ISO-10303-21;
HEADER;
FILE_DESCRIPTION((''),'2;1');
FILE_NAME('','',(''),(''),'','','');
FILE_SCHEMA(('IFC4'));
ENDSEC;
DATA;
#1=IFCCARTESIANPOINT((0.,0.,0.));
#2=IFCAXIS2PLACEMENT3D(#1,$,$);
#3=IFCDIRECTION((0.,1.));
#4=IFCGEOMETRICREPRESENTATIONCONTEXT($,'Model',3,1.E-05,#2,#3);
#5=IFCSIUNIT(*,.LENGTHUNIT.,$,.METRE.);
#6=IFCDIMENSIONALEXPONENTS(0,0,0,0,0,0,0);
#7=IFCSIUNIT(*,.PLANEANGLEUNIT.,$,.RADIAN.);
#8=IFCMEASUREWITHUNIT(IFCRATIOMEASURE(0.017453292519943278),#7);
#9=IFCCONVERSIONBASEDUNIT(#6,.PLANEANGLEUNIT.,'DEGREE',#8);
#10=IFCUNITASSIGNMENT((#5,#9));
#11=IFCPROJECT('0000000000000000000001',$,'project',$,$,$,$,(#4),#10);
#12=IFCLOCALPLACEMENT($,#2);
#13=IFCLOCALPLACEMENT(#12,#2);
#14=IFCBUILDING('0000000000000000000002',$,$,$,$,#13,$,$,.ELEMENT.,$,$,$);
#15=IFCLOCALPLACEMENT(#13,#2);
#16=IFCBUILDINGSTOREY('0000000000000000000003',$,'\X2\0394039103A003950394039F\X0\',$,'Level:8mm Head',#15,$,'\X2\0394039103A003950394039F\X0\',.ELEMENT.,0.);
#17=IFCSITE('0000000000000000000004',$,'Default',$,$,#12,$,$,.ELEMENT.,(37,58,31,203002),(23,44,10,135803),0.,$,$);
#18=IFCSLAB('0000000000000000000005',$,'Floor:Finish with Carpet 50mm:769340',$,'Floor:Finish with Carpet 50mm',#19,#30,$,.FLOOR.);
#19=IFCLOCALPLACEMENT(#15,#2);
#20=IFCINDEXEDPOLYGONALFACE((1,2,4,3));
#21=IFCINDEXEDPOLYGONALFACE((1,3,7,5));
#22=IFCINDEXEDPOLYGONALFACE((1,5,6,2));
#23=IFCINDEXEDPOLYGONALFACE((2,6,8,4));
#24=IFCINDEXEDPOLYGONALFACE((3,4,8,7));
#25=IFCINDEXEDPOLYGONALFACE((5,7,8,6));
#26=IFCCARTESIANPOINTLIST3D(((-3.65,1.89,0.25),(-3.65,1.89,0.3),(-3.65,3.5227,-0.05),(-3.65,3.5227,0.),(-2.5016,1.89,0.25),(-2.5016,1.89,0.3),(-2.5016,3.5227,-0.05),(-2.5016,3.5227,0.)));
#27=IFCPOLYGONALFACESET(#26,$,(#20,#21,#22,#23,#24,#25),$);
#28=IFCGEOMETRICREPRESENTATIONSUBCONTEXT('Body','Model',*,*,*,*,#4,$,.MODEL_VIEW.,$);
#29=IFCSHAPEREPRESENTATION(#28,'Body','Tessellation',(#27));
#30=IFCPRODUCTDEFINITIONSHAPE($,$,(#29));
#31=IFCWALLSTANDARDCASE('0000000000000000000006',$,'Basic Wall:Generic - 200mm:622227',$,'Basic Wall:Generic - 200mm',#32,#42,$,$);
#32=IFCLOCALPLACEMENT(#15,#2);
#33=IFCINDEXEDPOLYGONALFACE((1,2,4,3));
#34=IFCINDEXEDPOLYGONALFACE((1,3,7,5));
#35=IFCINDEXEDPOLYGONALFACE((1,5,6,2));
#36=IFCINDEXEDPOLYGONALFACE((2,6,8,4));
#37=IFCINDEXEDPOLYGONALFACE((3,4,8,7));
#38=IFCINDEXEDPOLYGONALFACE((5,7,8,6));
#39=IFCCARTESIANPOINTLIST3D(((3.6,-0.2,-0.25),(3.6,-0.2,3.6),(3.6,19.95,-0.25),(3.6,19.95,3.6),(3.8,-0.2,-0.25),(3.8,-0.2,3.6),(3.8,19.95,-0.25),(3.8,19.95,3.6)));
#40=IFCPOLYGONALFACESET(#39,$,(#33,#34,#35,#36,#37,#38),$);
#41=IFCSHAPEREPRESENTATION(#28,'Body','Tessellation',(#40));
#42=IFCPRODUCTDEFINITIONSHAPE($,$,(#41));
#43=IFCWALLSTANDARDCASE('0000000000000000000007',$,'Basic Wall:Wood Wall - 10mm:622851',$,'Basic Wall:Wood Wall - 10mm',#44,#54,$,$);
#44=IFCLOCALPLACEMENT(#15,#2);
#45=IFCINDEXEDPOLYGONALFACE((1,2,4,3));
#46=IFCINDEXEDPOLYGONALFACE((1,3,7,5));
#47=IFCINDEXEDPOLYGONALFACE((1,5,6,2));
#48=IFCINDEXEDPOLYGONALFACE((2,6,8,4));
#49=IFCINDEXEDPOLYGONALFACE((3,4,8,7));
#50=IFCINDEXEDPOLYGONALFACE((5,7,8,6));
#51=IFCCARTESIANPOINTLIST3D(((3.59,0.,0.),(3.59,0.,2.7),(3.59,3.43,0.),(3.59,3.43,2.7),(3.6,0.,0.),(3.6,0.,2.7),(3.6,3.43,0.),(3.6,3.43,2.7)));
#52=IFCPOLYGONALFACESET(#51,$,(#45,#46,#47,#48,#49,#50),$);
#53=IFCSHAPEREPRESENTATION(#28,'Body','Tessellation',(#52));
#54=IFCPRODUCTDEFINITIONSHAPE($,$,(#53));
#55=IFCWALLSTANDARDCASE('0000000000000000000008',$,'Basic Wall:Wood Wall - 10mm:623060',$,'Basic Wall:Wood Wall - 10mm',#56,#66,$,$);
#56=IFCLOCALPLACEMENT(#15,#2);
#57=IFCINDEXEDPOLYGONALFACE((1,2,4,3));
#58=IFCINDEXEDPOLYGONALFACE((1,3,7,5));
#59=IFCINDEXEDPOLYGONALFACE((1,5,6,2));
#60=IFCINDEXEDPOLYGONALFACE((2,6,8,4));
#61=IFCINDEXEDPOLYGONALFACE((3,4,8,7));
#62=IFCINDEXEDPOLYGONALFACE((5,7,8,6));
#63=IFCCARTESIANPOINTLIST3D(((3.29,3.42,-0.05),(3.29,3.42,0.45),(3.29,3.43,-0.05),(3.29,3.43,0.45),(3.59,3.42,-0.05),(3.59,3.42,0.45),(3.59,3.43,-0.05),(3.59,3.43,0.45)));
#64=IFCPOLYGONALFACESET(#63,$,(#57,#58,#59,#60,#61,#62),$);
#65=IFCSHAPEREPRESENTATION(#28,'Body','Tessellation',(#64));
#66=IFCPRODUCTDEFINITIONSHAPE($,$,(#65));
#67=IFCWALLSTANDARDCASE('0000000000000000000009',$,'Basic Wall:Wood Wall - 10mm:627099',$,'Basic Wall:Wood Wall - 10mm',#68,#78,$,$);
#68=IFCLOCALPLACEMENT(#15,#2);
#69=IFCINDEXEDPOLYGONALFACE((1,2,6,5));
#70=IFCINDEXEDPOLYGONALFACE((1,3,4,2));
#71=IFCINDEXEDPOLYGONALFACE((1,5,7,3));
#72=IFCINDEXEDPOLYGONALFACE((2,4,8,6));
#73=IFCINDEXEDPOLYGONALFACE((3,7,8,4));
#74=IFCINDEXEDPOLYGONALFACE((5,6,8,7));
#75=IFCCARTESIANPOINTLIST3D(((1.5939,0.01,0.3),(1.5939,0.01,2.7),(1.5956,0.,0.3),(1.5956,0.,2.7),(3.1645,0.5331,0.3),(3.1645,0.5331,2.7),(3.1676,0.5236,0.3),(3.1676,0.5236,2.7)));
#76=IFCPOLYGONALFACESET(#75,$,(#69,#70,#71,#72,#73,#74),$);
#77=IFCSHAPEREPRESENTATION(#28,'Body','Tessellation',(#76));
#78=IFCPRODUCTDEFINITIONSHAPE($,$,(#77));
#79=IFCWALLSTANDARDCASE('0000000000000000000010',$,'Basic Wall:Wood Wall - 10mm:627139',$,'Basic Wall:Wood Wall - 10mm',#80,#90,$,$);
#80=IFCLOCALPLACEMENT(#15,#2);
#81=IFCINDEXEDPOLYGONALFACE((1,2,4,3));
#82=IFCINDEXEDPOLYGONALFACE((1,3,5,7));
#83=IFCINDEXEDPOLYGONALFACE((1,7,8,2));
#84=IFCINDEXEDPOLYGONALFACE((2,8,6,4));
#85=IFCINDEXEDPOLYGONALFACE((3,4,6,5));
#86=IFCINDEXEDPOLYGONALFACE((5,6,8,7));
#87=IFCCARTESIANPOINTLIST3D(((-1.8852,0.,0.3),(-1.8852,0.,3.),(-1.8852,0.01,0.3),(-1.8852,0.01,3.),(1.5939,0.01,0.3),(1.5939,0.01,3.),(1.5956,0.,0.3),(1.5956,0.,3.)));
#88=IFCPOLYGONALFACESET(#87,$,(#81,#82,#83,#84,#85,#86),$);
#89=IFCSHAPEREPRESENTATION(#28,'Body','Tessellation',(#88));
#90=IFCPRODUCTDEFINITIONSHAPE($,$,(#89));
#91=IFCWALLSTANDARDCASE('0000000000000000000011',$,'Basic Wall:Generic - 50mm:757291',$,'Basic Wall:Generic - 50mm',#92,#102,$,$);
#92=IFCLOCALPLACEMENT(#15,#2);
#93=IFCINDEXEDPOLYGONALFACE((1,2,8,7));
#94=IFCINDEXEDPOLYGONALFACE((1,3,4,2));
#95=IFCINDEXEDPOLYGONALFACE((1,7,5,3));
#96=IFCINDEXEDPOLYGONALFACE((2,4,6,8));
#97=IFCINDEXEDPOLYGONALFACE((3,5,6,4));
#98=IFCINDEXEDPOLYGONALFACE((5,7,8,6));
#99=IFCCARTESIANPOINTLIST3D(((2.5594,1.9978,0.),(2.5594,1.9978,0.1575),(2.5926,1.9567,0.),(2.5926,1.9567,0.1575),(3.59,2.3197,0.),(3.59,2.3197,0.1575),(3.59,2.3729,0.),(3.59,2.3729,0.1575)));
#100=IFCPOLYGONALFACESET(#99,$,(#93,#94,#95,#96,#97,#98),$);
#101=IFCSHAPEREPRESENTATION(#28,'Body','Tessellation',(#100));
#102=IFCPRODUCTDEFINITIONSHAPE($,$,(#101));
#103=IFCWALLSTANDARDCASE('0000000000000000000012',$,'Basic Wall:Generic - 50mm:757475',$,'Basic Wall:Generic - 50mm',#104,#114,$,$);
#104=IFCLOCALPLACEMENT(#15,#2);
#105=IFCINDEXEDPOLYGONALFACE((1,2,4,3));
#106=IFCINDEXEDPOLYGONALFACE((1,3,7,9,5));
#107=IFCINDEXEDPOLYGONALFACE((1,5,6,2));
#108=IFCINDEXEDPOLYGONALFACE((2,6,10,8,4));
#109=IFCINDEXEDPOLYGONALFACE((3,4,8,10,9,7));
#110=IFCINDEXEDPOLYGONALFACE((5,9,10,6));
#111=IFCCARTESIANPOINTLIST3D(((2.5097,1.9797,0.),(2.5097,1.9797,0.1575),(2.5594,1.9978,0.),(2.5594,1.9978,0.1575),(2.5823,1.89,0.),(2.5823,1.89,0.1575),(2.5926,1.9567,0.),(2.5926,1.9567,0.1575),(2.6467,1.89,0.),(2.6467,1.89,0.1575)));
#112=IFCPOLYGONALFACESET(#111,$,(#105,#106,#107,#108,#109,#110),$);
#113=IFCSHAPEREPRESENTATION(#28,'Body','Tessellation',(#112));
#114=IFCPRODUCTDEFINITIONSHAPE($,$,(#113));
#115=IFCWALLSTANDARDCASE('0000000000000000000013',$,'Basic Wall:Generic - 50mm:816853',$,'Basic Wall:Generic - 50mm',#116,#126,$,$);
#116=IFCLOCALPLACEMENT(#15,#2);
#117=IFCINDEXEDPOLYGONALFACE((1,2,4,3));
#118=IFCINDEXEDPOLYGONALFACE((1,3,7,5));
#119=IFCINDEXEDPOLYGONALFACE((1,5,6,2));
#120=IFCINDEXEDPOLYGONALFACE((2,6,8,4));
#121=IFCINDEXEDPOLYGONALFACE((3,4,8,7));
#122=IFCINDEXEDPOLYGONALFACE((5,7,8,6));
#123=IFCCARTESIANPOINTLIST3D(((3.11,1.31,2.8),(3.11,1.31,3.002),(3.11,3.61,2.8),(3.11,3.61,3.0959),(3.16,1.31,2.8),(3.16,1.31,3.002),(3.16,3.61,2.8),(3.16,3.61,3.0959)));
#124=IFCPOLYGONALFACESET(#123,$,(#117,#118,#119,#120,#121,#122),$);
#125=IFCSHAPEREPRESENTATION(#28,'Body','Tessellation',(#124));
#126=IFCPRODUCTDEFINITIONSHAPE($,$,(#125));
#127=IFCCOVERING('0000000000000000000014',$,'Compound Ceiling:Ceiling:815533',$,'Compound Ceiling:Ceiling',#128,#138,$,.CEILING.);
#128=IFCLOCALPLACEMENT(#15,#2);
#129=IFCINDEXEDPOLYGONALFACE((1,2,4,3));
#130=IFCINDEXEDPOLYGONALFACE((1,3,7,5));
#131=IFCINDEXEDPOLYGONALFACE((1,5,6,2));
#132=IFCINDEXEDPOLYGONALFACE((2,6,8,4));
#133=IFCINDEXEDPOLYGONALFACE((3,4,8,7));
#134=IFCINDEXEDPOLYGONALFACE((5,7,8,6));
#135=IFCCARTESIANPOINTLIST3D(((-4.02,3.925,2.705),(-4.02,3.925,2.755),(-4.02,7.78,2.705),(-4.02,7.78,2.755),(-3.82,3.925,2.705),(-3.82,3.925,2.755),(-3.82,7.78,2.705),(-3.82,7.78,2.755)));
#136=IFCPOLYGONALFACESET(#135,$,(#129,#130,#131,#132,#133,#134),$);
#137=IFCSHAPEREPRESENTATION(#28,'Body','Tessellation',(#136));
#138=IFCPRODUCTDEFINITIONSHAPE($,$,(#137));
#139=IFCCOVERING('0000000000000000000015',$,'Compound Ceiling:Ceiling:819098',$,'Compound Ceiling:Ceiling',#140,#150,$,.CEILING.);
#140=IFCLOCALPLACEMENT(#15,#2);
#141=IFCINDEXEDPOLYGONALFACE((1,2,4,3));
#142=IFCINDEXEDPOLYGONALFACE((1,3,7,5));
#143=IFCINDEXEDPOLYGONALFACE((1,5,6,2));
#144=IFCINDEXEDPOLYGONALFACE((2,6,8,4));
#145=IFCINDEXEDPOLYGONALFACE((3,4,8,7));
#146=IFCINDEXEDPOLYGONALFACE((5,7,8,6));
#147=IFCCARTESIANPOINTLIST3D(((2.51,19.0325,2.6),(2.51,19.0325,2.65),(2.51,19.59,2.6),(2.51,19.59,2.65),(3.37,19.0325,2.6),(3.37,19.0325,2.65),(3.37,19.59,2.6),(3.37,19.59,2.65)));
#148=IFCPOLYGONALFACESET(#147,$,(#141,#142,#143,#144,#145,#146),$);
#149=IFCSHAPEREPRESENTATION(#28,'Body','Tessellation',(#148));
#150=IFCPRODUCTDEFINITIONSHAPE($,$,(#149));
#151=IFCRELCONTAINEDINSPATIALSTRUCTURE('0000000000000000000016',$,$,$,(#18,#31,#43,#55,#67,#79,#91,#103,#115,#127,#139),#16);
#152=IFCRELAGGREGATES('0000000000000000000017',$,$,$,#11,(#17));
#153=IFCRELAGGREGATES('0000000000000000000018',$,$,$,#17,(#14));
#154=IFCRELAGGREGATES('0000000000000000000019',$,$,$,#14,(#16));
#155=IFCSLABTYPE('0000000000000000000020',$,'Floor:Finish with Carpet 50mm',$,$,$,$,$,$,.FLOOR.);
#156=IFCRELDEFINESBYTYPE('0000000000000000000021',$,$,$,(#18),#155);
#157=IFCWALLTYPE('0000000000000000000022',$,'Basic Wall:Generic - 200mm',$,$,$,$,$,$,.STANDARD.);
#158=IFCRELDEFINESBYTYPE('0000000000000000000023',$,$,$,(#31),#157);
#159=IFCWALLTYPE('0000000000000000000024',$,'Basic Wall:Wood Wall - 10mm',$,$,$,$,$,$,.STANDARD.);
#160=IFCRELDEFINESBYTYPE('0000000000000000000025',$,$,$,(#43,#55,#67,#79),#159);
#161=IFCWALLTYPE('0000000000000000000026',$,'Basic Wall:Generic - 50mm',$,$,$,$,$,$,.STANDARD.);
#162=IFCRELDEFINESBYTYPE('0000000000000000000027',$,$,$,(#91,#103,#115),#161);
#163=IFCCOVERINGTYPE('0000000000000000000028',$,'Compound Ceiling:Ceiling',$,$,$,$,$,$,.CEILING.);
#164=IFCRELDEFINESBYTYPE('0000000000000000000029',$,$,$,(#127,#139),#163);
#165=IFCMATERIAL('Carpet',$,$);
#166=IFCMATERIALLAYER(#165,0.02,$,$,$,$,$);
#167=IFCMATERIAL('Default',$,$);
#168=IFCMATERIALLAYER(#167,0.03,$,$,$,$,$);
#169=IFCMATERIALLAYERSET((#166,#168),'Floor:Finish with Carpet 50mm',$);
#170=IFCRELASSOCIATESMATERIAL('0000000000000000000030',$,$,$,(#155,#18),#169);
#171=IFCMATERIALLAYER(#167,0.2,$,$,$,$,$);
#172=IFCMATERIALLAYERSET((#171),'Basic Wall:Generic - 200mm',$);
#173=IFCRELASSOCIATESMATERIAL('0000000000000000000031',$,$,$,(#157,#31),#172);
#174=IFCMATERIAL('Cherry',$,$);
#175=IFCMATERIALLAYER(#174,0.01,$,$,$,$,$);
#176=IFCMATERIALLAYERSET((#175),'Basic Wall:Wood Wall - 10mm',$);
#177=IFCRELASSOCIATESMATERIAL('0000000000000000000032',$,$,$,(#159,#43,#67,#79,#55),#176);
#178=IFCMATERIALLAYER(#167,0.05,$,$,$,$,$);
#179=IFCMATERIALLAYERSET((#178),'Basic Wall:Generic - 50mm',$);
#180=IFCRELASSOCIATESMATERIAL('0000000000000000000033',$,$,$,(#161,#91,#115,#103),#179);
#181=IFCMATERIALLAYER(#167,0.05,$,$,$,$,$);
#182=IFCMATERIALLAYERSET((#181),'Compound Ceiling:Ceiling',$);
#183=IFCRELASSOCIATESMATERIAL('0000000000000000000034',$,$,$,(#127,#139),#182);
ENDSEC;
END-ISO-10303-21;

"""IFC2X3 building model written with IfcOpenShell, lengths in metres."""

from ifc_helpers import new_model, entity, si_unit, converted_unit, direction, frame, frame_2d, origin, place, context, subcontext, project, spatial, polyline, rectangle, outline, extrude, clip, halfspace, bounded_halfspace, material, layer, layer_set, layer_usage, type_object, element, save


model = new_model("IFC2X3")

# Units and contexts
model_context = context("Model", 3, precision=1e-05, world=origin(), true_north=direction((0.0, 1.0)))
body_context = subcontext(model_context, "Body", "Model", "MODEL_VIEW")
ifc_project = project(units=[si_unit("LENGTHUNIT", "METRE"), converted_unit("PLANEANGLEUNIT", "DEGREE", entity("IfcRatioMeasure", 0.017453292519943278), si_unit("PLANEANGLEUNIT", "RADIAN"), dimensions=[0, 0, 0, 0, 0, 0, 0])], contexts=[model_context])

# Site, building, storey
site_placement = place(None, origin())
site = spatial("IfcSite", under=ifc_project, at=site_placement, Name="Default", CompositionType="ELEMENT", RefLatitude=(37, 58, 31, 203002), RefLongitude=(23, 44, 10, 135803), RefElevation=0.0)
building_placement = place(site_placement, origin())
building = spatial("IfcBuilding", under=site, at=building_placement, CompositionType="ELEMENT")
storey_placement = place(building_placement, origin())
storey = spatial("IfcBuildingStorey", under=building, at=storey_placement, Name="ΔΑΠΕΔΟ", ObjectType="Level:8mm Head", LongName="ΔΑΠΕΔΟ", CompositionType="ELEMENT", Elevation=0.0)

# Slab
ifc_material_1 = material(Name="Carpet")
ifc_layer_1 = layer(ifc_material_1, 0.02)
ifc_material_2 = material(Name="Default")
ifc_layer_2 = layer(ifc_material_2, 0.03)
ifc_layer_set_1 = layer_set([ifc_layer_1, ifc_layer_2], Name="Floor:Finish with Carpet 50mm")
ifc_layer_usage_1 = layer_usage(ifc_layer_set_1, "AXIS3", "POSITIVE", 0.0)
slab_type = type_object("IfcSlabType", Name="Floor:Finish with Carpet 50mm", PredefinedType="FLOOR", material=ifc_layer_set_1)
slab_1_placement = place(storey_placement, origin())
element("IfcSlab", 1, at=slab_1_placement, inside=storey, type_object=slab_type, material=ifc_layer_usage_1, Name="Floor:Finish with Carpet 50mm:769340", ObjectType="Floor:Finish with Carpet 50mm", PredefinedType="FLOOR", context=body_context, shape_type="SweptSolid", body=[
    clip(clip(extrude(rectangle(XDim=1.66, YDim=1.1484, at=frame_2d((0.0, 0.0), x_axis=(1.0, 0.0))), frame((-3.0758, 2.7063, 0.15), z_axis=(0.0, -0.180721, -0.983534), x_axis=(0.0, 0.983534, -0.180721)), (0.180721, 0.0, 0.983534), 0.0508), halfspace(frame((-3.0758, 2.7063, 0.1), z_axis=(0.0, -0.180721, -0.983534), x_axis=(0.0, -0.983534, 0.180721)), False)), halfspace(frame((-3.0758, 2.7063, 0.15), z_axis=(0.0, 0.180721, 0.983534), x_axis=(0.0, -0.983534, 0.180721)), False)),
])

# Walls
ifc_layer_3 = layer(ifc_material_2, 0.2)
ifc_layer_set_2 = layer_set([ifc_layer_3], Name="Basic Wall:Generic - 200mm")
ifc_layer_usage_2 = layer_usage(ifc_layer_set_2, "AXIS2", "NEGATIVE", 0.1)
wall_type_1 = type_object("IfcWallType", Name="Basic Wall:Generic - 200mm", PredefinedType="STANDARD", material=ifc_layer_set_2)
wall_1_placement = place(storey_placement, frame((3.7, -0.2, -0.25), z_axis=(0.0, 0.0, 1.0), x_axis=(0.0, 1.0, 0.0)))
element("IfcWallStandardCase", 2, at=wall_1_placement, inside=storey, type_object=wall_type_1, material=ifc_layer_usage_2, Name="Basic Wall:Generic - 200mm:622227", ObjectType="Basic Wall:Generic - 200mm", context=body_context, shape_type="SweptSolid", body=[
    extrude(rectangle(XDim=20.15, YDim=0.2, at=frame_2d((10.075, 0.0), x_axis=(-1.0, 0.0))), origin(), (0.0, 0.0, 1.0), 3.85),
])
ifc_material_3 = material(Name="Cherry")
ifc_layer_4 = layer(ifc_material_3, 0.01)
ifc_layer_set_3 = layer_set([ifc_layer_4], Name="Basic Wall:Wood Wall - 10mm")
ifc_layer_usage_3 = layer_usage(ifc_layer_set_3, "AXIS2", "NEGATIVE", 0.005)
wall_type_2 = type_object("IfcWallType", Name="Basic Wall:Wood Wall - 10mm", PredefinedType="STANDARD", material=ifc_layer_set_3)
wall_2_placement = place(storey_placement, frame((3.595, 0.0, 0.0), z_axis=(0.0, 0.0, 1.0), x_axis=(0.0, 1.0, 0.0)))
element("IfcWallStandardCase", 3, at=wall_2_placement, inside=storey, type_object=wall_type_2, material=ifc_layer_usage_3, Name="Basic Wall:Wood Wall - 10mm:622851", ObjectType="Basic Wall:Wood Wall - 10mm", context=body_context, shape_type="Clipping", body=[
    clip(extrude(rectangle(XDim=3.43, YDim=0.01, at=frame_2d((1.715, 0.0), x_axis=(-1.0, 0.0))), origin(), (0.0, 0.0, 1.0), 2.7), bounded_halfspace(frame((0.0, -0.005, 2.7), z_axis=(0.0, 0.0, -1.0), x_axis=(0.0, -1.0, 0.0)), True, frame((0.0, -0.005, 2.7)), polyline([(0.0, 0.0), (1.31, 0.0), (1.31, 0.01), (0.0, 0.01), (0.0, 0.0)]))),
])
ifc_layer_usage_4 = layer_usage(ifc_layer_set_3, "AXIS2", "POSITIVE", -0.005)
wall_3_placement = place(storey_placement, frame((3.59, 3.425, -0.05), z_axis=(0.0, 0.0, 1.0), x_axis=(-1.0, 0.0, 0.0)))
element("IfcWallStandardCase", 4, at=wall_3_placement, inside=storey, type_object=wall_type_2, material=ifc_layer_usage_4, Name="Basic Wall:Wood Wall - 10mm:623060", ObjectType="Basic Wall:Wood Wall - 10mm", context=body_context, shape_type="Clipping", body=[
    clip(extrude(rectangle(XDim=0.3, YDim=0.01, at=frame_2d((0.15, 0.0), x_axis=(-1.0, 0.0))), origin(), (0.0, 0.0, 1.0), 0.5), bounded_halfspace(frame((0.3, -0.005, 0.0), z_axis=(0.0, 0.0, 1.0), x_axis=(0.0, -1.0, 0.0)), True, frame((0.3, -0.005, 0.0), z_axis=(0.0, 0.0, 1.0), x_axis=(0.0, -1.0, 0.0)), polyline([(0.0, 0.0), (-0.01, 0.0), (-0.01, -0.3), (0.0, -0.3), (0.0, -0.01), (0.0, 0.0)]))),
])
wall_4_placement = place(storey_placement, frame((3.166, 0.5284, 0.3), z_axis=(0.0, 0.0, 1.0), x_axis=(-0.948757, -0.316008, 0.0)))
element("IfcWallStandardCase", 5, at=wall_4_placement, inside=storey, type_object=wall_type_2, material=ifc_layer_usage_3, Name="Basic Wall:Wood Wall - 10mm:627099", ObjectType="Basic Wall:Wood Wall - 10mm", context=body_context, shape_type="SweptSolid", body=[
    extrude(outline(polyline([(1.6553, -0.005), (1.657, 0.005), (0.0, 0.005), (0.0, -0.005), (1.6553, -0.005)])), origin(), (0.0, 0.0, 1.0), 2.4),
])
wall_5_placement = place(storey_placement, frame((1.5956, 0.005, 0.3), z_axis=(0.0, 0.0, 1.0), x_axis=(-1.0, 0.0, 0.0)))
element("IfcWallStandardCase", 6, at=wall_5_placement, inside=storey, type_object=wall_type_2, material=ifc_layer_usage_3, Name="Basic Wall:Wood Wall - 10mm:627139", ObjectType="Basic Wall:Wood Wall - 10mm", context=body_context, shape_type="SweptSolid", body=[
    extrude(outline(polyline([(3.4808, -0.005), (3.4808, 0.005), (0.0, 0.005), (0.0016, -0.005), (3.4808, -0.005)])), origin(), (0.0, 0.0, 1.0), 2.7),
])
ifc_layer_5 = layer(ifc_material_2, 0.05)
ifc_layer_set_4 = layer_set([ifc_layer_5], Name="Basic Wall:Generic - 50mm")
ifc_layer_usage_5 = layer_usage(ifc_layer_set_4, "AXIS2", "NEGATIVE", 0.025)
wall_type_3 = type_object("IfcWallType", Name="Basic Wall:Generic - 50mm", PredefinedType="STANDARD", material=ifc_layer_set_4)
wall_6_placement = place(storey_placement, frame((2.5679, 1.9743, 0.0), z_axis=(0.0, 0.0, 1.0), x_axis=(0.939693, 0.34202, 0.0)))
element("IfcWallStandardCase", 7, at=wall_6_placement, inside=storey, type_object=wall_type_3, material=ifc_layer_usage_5, Name="Basic Wall:Generic - 50mm:757291", ObjectType="Basic Wall:Generic - 50mm", context=body_context, shape_type="Clipping", body=[
    clip(extrude(outline(polyline([(0.0172, -0.025), (1.0786, -0.025), (1.0968, 0.025), (0.0, 0.025), (0.0172, -0.025)])), origin(), (0.0, 0.0, 1.0), 0.1575), bounded_halfspace(frame((1.0786, -0.025, 0.1575), z_axis=(-0.939693, 0.34202, 0.0), x_axis=(-0.34202, -0.939693, 0.0)), True, frame((1.0786, -0.025, 0.1575), z_axis=(-0.939693, 0.34202, 0.0), x_axis=(-0.34202, -0.939693, 0.0)), polyline([(0.0, 0.0), (-0.0532, 0.0), (-0.0532, -0.1575), (0.0, -0.1575), (0.0, -0.05), (0.0, 0.0)]))),
])
ifc_layer_usage_6 = layer_usage(ifc_layer_set_4, "AXIS2", "POSITIVE", -0.025)
wall_7_placement = place(storey_placement, frame((2.5291, 1.9955, 0.0), z_axis=(0.0, 0.0, 1.0), x_axis=(0.62932, -0.777146, 0.0)))
element("IfcWallStandardCase", 8, at=wall_7_placement, inside=storey, type_object=wall_type_3, material=ifc_layer_usage_6, Name="Basic Wall:Generic - 50mm:757475", ObjectType="Basic Wall:Generic - 50mm", context=body_context, shape_type="SweptSolid", body=[
    extrude(outline(polyline([(0.1155, -0.025), (0.156, 0.025), (0.0701, 0.025), (0.0172, 0.025), (0.0, -0.025), (0.1155, -0.025)])), origin(), (0.0, 0.0, 1.0), 0.1575),
])
wall_8_placement = place(storey_placement, frame((3.135, 1.31, 2.8), z_axis=(0.0, 0.0, 1.0), x_axis=(0.0, 1.0, 0.0)))
element("IfcWallStandardCase", 9, at=wall_8_placement, inside=storey, type_object=wall_type_3, material=ifc_layer_usage_5, Name="Basic Wall:Generic - 50mm:816853", ObjectType="Basic Wall:Generic - 50mm", context=body_context, shape_type="Clipping", body=[
    clip(extrude(rectangle(XDim=2.3, YDim=0.05, at=frame_2d((1.15, 0.0), x_axis=(-1.0, 0.0))), origin(), (0.0, 0.0, 1.0), 0.2959), bounded_halfspace(frame((0.0, -0.025, 0.202), z_axis=(0.040782, 0.0, -0.999168), x_axis=(0.999168, 0.0, 0.040782)), True, frame((0.0, -0.025, 0.202)), polyline([(0.0, 0.0), (1.6289, 0.0), (2.17, 0.0), (2.3, 0.0), (2.3, 0.05), (0.0, 0.05), (0.0, 0.0)]))),
])

# Coverings
ifc_layer_6 = layer(ifc_material_2, 0.05)
ifc_layer_set_5 = layer_set([ifc_layer_6], Name="Compound Ceiling:Ceiling")
ifc_layer_usage_7 = layer_usage(ifc_layer_set_5, "AXIS3", "POSITIVE", 0.0)
covering_type = type_object("IfcCoveringType", Name="Compound Ceiling:Ceiling", PredefinedType="CEILING")
covering_1_placement = place(storey_placement, origin())
element("IfcCovering", 10, at=covering_1_placement, inside=storey, type_object=covering_type, material=ifc_layer_usage_7, Name="Compound Ceiling:Ceiling:815533", ObjectType="Compound Ceiling:Ceiling", PredefinedType="CEILING", context=body_context, shape_type="SweptSolid", body=[
    extrude(rectangle(XDim=0.2, YDim=3.855, at=frame_2d((0.0, 0.0), x_axis=(1.0, 0.0))), frame((-3.92, 5.8525, 2.705), z_axis=(0.0, 0.0, 1.0), x_axis=(-1.0, 0.0, 0.0)), (0.0, 0.0, 1.0), 0.05),
])
covering_2_placement = place(storey_placement, origin())
element("IfcCovering", 11, at=covering_2_placement, inside=storey, type_object=covering_type, material=ifc_layer_usage_7, Name="Compound Ceiling:Ceiling:819098", ObjectType="Compound Ceiling:Ceiling", PredefinedType="CEILING", context=body_context, shape_type="SweptSolid", body=[
    extrude(rectangle(XDim=0.86, YDim=0.5575, at=frame_2d((0.0, 0.0), x_axis=(1.0, 0.0))), frame((2.94, 19.3113, 2.6), z_axis=(0.0, 0.0, 1.0), x_axis=(-1.0, 0.0, 0.0)), (0.0, 0.0, 1.0), 0.05),
])

save(model, "model.ifc")
